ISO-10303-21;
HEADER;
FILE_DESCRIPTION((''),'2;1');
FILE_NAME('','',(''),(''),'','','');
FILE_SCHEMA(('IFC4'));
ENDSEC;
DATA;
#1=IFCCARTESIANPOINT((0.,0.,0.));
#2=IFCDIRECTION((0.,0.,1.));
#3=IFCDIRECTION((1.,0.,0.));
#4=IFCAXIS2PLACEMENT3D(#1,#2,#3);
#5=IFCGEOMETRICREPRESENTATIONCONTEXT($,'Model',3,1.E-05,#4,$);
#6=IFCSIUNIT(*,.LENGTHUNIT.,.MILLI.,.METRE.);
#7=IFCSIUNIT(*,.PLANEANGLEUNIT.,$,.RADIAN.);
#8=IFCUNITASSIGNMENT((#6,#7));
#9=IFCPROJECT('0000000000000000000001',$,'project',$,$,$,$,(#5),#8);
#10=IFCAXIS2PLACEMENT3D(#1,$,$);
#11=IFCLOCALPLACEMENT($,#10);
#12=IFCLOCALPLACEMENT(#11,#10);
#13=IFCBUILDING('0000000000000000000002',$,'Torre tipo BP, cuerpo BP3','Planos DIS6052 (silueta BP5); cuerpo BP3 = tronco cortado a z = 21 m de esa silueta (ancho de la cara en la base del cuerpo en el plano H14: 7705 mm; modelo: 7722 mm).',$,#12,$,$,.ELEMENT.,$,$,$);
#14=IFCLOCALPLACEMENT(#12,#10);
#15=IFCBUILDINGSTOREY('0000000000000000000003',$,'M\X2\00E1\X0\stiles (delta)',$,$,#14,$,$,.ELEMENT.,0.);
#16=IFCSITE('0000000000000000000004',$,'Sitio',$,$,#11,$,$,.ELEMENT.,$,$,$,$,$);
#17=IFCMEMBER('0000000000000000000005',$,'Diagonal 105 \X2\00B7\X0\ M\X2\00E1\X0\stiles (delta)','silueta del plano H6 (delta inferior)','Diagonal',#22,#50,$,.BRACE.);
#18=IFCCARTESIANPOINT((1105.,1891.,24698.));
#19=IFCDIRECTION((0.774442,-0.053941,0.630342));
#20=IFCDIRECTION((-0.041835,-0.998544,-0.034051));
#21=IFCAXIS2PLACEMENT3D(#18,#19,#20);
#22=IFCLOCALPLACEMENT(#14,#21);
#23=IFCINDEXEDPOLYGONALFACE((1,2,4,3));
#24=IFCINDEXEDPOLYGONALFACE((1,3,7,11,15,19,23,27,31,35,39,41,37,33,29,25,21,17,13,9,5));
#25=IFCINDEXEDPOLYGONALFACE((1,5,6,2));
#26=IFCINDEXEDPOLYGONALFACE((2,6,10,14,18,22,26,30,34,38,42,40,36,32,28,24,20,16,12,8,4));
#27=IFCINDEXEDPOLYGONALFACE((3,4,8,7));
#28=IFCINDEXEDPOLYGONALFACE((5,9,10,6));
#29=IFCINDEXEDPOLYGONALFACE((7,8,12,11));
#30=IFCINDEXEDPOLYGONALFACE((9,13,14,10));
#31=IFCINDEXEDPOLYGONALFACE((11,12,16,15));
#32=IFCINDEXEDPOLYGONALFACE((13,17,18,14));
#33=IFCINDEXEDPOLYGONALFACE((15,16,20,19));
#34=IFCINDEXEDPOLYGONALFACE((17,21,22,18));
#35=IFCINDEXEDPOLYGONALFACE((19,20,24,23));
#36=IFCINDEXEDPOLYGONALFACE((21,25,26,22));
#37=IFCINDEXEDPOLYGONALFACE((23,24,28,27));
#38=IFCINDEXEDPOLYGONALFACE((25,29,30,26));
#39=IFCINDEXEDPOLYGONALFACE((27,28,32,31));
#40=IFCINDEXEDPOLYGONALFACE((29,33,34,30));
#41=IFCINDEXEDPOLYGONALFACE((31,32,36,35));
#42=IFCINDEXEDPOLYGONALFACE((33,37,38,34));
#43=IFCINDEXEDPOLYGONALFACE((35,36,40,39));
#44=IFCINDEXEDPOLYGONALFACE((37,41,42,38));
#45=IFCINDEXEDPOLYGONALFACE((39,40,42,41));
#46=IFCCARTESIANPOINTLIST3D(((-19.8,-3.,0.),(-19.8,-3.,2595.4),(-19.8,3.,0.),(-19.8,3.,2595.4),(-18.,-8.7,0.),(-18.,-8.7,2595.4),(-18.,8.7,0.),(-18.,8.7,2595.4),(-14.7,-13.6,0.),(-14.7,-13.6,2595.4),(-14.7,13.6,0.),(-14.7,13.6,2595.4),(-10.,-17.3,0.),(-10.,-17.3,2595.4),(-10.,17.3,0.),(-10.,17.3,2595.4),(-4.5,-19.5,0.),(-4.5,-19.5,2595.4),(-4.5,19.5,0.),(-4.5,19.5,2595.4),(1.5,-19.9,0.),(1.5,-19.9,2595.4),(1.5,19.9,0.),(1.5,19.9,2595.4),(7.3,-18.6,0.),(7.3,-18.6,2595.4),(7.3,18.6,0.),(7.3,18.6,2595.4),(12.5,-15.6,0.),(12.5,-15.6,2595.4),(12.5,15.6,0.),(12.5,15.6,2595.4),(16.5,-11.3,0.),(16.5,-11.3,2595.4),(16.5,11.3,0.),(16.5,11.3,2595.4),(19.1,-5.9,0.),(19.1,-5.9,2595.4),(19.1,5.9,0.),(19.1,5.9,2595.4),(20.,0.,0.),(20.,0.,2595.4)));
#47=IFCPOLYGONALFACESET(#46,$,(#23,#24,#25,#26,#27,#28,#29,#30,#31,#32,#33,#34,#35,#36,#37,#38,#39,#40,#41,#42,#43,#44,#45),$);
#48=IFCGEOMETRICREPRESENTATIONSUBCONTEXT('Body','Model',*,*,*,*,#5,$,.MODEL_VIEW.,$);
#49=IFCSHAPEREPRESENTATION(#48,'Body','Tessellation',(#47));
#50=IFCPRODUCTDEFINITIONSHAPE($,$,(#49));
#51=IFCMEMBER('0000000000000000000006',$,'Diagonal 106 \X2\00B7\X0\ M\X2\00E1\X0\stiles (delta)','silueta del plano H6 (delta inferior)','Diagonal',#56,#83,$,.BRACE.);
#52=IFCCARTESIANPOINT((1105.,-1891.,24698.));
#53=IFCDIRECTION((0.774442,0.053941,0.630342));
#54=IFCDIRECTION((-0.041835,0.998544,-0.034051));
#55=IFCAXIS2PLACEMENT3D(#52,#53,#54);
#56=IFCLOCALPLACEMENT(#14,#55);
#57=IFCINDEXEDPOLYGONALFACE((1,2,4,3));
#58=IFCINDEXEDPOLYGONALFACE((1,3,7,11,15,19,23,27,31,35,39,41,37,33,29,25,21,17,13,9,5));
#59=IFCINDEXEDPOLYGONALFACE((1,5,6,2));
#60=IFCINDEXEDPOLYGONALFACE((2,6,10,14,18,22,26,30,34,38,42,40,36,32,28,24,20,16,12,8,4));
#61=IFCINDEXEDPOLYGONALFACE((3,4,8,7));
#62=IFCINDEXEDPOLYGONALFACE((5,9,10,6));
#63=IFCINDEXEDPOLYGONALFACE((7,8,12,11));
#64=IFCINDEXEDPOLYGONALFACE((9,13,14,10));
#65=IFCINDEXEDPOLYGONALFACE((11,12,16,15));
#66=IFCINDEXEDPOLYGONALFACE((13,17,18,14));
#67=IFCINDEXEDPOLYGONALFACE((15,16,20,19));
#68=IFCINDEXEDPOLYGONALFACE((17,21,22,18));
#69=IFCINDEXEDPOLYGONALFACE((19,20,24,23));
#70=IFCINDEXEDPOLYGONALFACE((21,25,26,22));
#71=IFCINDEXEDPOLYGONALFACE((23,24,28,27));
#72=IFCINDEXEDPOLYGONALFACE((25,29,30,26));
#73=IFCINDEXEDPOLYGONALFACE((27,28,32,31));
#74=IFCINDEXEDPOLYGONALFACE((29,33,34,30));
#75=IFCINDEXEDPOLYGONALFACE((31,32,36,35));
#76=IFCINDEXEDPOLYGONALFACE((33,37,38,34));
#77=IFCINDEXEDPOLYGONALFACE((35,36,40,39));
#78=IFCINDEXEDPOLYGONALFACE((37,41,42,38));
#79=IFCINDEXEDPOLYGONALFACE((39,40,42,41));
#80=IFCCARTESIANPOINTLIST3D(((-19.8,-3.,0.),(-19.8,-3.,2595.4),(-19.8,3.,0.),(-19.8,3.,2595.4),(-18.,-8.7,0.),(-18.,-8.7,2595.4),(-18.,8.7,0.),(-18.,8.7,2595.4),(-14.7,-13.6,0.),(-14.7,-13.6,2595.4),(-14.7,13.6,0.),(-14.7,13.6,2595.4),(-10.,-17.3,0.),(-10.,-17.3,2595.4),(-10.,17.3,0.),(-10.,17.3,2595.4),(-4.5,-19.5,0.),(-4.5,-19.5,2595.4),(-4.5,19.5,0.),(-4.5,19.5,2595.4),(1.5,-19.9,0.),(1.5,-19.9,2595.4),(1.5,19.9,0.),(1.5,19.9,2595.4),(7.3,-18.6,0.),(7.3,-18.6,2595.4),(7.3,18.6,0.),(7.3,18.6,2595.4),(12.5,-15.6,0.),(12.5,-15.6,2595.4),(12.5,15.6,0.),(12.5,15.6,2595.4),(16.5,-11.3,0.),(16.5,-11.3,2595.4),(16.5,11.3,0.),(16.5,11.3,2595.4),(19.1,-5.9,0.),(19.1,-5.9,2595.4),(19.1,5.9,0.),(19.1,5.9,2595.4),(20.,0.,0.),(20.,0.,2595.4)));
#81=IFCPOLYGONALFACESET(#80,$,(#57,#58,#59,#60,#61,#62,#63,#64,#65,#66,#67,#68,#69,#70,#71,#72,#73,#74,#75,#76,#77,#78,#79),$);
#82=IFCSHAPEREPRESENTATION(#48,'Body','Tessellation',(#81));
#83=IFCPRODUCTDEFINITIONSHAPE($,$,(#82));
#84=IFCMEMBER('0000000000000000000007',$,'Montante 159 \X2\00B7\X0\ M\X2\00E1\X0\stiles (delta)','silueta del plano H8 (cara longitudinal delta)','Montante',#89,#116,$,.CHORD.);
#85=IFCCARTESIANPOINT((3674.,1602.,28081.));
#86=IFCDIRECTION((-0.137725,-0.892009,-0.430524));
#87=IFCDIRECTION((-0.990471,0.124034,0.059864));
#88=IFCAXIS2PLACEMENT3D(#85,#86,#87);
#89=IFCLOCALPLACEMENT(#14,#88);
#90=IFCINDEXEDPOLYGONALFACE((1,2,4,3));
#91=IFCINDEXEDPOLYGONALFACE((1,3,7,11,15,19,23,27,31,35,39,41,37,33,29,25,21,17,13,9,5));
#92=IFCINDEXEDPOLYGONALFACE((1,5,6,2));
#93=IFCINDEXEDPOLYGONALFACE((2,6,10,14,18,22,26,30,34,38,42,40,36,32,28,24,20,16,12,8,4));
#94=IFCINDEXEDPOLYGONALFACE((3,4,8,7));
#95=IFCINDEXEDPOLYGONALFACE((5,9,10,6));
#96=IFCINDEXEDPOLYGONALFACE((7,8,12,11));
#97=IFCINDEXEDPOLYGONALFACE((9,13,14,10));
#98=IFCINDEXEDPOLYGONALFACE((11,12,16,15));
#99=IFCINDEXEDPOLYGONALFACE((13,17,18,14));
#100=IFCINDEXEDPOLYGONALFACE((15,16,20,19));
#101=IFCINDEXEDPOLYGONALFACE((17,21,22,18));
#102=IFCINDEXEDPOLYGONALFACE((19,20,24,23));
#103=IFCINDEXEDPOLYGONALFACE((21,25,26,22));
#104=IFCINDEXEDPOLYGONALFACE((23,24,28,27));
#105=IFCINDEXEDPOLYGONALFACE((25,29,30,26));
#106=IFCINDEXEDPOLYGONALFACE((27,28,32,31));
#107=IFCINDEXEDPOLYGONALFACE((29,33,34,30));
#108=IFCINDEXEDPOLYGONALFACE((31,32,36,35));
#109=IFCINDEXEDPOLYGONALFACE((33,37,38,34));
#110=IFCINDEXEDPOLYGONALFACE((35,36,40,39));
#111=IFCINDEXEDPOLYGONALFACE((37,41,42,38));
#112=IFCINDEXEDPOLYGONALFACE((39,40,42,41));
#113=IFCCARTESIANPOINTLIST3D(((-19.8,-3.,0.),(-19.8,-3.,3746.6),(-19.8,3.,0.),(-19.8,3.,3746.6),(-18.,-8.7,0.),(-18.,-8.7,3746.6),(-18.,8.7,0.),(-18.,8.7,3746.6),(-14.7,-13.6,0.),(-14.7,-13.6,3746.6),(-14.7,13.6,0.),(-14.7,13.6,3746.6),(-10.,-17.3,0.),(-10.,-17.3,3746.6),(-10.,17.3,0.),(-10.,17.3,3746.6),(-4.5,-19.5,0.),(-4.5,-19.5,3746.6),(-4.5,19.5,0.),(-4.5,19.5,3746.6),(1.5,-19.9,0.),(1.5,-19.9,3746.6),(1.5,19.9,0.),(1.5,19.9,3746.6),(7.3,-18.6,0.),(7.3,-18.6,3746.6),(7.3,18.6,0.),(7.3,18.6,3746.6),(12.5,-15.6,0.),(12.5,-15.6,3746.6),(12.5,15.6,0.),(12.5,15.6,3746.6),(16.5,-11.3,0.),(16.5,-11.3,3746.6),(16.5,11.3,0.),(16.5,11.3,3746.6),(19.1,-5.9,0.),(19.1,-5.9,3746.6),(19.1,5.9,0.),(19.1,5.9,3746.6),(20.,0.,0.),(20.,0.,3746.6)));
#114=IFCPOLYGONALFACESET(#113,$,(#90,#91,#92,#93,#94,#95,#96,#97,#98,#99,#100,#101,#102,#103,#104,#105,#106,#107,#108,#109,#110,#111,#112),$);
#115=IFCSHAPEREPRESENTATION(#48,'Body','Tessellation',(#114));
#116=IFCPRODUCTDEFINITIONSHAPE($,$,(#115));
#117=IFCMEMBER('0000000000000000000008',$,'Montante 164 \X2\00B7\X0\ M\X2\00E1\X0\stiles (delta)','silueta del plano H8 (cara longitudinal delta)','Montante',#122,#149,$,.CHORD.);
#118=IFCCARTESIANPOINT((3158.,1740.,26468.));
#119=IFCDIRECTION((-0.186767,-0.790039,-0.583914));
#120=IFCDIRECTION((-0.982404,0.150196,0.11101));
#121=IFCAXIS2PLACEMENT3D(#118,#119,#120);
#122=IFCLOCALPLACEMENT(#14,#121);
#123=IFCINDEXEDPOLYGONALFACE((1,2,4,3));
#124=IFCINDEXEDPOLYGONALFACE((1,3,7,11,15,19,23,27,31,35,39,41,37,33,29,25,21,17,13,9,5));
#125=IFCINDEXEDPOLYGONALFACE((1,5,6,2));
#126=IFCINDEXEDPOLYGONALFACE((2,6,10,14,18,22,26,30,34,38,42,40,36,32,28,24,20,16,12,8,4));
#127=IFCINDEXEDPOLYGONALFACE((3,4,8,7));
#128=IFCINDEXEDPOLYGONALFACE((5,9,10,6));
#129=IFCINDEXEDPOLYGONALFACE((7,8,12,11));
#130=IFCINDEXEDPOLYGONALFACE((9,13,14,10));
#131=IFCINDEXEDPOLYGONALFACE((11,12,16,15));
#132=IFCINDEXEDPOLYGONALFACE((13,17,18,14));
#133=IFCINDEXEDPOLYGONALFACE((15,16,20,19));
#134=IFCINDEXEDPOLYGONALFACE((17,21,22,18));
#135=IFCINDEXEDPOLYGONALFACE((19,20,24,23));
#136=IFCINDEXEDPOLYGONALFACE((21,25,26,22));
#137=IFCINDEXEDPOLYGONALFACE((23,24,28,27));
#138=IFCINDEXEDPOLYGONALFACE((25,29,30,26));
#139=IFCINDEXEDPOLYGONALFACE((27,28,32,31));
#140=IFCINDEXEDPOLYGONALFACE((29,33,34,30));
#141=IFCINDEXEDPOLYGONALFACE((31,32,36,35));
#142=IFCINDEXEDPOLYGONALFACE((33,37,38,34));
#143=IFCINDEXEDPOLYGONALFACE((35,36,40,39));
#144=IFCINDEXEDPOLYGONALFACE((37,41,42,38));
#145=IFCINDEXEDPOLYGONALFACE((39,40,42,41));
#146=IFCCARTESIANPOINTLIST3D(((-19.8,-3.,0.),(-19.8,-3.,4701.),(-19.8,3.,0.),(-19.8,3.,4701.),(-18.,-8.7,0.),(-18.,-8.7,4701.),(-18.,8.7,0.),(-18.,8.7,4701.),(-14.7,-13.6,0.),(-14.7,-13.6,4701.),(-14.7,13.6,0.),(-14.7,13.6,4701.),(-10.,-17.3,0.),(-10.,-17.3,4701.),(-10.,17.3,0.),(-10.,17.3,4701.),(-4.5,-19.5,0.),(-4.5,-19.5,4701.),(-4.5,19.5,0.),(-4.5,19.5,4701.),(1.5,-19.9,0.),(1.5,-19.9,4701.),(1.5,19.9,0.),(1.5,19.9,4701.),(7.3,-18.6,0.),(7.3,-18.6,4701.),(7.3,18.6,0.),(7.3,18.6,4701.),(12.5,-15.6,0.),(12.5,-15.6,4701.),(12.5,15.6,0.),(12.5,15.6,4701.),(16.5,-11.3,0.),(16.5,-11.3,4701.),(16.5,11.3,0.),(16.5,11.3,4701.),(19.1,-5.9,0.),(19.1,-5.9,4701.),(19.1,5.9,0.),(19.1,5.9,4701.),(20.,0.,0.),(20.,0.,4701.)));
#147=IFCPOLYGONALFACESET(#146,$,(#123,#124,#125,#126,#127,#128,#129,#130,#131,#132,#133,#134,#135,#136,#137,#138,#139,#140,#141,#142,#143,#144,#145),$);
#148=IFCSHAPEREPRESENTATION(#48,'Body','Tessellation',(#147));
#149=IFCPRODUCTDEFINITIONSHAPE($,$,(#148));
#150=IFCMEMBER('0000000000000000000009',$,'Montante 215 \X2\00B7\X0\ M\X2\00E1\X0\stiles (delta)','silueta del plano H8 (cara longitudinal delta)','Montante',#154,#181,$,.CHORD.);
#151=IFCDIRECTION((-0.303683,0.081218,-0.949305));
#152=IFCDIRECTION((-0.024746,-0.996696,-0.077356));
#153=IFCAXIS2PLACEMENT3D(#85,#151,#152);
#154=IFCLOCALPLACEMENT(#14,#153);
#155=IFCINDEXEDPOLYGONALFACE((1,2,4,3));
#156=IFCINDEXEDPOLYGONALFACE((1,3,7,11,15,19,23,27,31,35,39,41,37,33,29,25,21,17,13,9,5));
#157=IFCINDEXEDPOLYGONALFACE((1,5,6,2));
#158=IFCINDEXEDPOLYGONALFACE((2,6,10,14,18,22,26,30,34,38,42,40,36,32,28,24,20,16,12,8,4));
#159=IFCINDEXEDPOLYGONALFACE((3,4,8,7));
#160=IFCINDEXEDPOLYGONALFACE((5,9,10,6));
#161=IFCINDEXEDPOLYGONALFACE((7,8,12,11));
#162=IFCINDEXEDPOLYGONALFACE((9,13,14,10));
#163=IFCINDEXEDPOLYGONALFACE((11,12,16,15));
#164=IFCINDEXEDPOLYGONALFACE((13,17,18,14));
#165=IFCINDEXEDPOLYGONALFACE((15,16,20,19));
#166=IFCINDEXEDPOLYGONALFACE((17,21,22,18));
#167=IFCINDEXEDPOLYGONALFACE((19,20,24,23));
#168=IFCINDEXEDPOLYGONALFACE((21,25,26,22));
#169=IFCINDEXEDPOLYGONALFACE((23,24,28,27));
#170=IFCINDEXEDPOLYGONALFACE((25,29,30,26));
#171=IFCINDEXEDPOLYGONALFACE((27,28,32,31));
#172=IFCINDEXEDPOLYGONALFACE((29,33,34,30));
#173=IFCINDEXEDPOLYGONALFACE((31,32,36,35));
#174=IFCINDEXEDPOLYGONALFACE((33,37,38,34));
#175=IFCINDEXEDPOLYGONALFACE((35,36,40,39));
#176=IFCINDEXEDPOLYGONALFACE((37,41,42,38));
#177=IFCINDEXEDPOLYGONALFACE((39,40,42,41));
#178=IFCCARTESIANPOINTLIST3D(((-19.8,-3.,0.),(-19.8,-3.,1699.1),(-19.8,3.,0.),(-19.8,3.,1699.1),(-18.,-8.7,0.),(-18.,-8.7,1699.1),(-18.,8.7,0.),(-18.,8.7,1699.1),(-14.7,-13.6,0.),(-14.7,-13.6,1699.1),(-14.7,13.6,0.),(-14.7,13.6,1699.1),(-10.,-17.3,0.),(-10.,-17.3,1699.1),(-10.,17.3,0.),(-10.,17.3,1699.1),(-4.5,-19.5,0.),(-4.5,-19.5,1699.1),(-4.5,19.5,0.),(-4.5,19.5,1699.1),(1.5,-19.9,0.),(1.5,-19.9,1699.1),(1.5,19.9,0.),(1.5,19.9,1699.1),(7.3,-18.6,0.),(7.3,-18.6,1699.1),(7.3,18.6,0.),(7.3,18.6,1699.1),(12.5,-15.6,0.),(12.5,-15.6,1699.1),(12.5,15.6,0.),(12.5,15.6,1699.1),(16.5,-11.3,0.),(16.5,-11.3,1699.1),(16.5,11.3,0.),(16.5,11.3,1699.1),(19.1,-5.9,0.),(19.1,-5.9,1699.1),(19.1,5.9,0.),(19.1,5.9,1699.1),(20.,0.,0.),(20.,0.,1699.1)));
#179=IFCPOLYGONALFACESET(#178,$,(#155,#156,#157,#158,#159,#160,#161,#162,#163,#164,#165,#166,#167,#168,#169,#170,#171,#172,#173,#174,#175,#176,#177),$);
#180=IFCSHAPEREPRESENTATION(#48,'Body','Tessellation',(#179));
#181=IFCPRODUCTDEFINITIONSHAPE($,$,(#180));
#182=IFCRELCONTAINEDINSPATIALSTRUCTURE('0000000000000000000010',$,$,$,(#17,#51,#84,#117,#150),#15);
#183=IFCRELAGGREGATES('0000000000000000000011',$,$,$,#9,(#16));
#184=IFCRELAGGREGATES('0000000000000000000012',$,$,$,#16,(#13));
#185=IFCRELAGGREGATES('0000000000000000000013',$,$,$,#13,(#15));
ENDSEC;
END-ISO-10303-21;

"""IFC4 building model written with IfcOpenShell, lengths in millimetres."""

from ifc_helpers import new_model, si_unit, frame, origin, origin_with_axes, place, context, subcontext, project, spatial, circle, extrude, element, save


model = new_model("IFC4")

# Units and contexts
model_context = context("Model", 3, precision=1e-05, world=origin_with_axes())
body_context = subcontext(model_context, "Body", "Model", "MODEL_VIEW")
ifc_project = project(units=[si_unit("LENGTHUNIT", "METRE", prefix="MILLI"), si_unit("PLANEANGLEUNIT", "RADIAN")], contexts=[model_context])

# Site, building, storey
site_placement = place(None, origin())
site = spatial("IfcSite", under=ifc_project, at=site_placement, Name="Sitio", CompositionType="ELEMENT")
building_placement = place(site_placement, origin())
building = spatial("IfcBuilding", under=site, at=building_placement, Name="Torre tipo BP, cuerpo BP3", Description="Planos DIS6052 (silueta BP5); cuerpo BP3 = tronco cortado a z = 21 m de esa silueta (ancho de la cara en la base del cuerpo en el plano H14: 7705 mm; modelo: 7722 mm).", CompositionType="ELEMENT")
storey_placement = place(building_placement, origin())
storey = spatial("IfcBuildingStorey", under=building, at=storey_placement, Name="Mástiles (delta)", CompositionType="ELEMENT", Elevation=0.0)

# Members
for number, where, z_axis, x_axis, name in (
    (1, (1105.0, 1891.0, 24698.0), (0.774442, -0.053941, 0.630342), (-0.041835, -0.998544, -0.034051), "Diagonal 105 · Mástiles (delta)"),
    (2, (1105.0, -1891.0, 24698.0), (0.774442, 0.053941, 0.630342), (-0.041835, 0.998544, -0.034051), "Diagonal 106 · Mástiles (delta)"),
):
    element("IfcMember", number, at=place(storey_placement, frame(where, z_axis=z_axis, x_axis=x_axis)), inside=storey, Name=name, Description="silueta del plano H6 (delta inferior)", ObjectType="Diagonal", PredefinedType="BRACE", context=body_context, shape_type="SweptSolid", body=[
        extrude(circle(Radius=20.0), None, (0.0, 0.0, 1.0), 2595.4),
    ])
member_1_placement = place(storey_placement, frame((3674.0, 1602.0, 28081.0), z_axis=(-0.137725, -0.892009, -0.430524), x_axis=(-0.990471, 0.124034, 0.059864)))
element("IfcMember", 3, at=member_1_placement, inside=storey, Name="Montante 159 · Mástiles (delta)", Description="silueta del plano H8 (cara longitudinal delta)", ObjectType="Montante", PredefinedType="CHORD", context=body_context, shape_type="SweptSolid", body=[
    extrude(circle(Radius=20.0), None, (0.0, 0.0, 1.0), 3746.6),
])
for number, where, z_axis, x_axis, name in (
    (4, (3158.0, 1740.0, 26468.0), (-0.186767, -0.790039, -0.583914), (-0.982404, 0.150196, 0.11101), "Montante 164 · Mástiles (delta)"),
):
    element("IfcMember", number, at=place(storey_placement, frame(where, z_axis=z_axis, x_axis=x_axis)), inside=storey, Name=name, Description="silueta del plano H8 (cara longitudinal delta)", ObjectType="Montante", PredefinedType="CHORD", context=body_context, shape_type="SweptSolid", body=[
        extrude(circle(Radius=20.0), None, (0.0, 0.0, 1.0), 4701.0),
    ])
member_2_placement = place(storey_placement, frame((3674.0, 1602.0, 28081.0), z_axis=(-0.303683, 0.081218, -0.949305), x_axis=(-0.024746, -0.996696, -0.077356)))
element("IfcMember", 5, at=member_2_placement, inside=storey, Name="Montante 215 · Mástiles (delta)", Description="silueta del plano H8 (cara longitudinal delta)", ObjectType="Montante", PredefinedType="CHORD", context=body_context, shape_type="SweptSolid", body=[
    extrude(circle(Radius=20.0), None, (0.0, 0.0, 1.0), 1699.1),
])

save(model, "model.ifc")
